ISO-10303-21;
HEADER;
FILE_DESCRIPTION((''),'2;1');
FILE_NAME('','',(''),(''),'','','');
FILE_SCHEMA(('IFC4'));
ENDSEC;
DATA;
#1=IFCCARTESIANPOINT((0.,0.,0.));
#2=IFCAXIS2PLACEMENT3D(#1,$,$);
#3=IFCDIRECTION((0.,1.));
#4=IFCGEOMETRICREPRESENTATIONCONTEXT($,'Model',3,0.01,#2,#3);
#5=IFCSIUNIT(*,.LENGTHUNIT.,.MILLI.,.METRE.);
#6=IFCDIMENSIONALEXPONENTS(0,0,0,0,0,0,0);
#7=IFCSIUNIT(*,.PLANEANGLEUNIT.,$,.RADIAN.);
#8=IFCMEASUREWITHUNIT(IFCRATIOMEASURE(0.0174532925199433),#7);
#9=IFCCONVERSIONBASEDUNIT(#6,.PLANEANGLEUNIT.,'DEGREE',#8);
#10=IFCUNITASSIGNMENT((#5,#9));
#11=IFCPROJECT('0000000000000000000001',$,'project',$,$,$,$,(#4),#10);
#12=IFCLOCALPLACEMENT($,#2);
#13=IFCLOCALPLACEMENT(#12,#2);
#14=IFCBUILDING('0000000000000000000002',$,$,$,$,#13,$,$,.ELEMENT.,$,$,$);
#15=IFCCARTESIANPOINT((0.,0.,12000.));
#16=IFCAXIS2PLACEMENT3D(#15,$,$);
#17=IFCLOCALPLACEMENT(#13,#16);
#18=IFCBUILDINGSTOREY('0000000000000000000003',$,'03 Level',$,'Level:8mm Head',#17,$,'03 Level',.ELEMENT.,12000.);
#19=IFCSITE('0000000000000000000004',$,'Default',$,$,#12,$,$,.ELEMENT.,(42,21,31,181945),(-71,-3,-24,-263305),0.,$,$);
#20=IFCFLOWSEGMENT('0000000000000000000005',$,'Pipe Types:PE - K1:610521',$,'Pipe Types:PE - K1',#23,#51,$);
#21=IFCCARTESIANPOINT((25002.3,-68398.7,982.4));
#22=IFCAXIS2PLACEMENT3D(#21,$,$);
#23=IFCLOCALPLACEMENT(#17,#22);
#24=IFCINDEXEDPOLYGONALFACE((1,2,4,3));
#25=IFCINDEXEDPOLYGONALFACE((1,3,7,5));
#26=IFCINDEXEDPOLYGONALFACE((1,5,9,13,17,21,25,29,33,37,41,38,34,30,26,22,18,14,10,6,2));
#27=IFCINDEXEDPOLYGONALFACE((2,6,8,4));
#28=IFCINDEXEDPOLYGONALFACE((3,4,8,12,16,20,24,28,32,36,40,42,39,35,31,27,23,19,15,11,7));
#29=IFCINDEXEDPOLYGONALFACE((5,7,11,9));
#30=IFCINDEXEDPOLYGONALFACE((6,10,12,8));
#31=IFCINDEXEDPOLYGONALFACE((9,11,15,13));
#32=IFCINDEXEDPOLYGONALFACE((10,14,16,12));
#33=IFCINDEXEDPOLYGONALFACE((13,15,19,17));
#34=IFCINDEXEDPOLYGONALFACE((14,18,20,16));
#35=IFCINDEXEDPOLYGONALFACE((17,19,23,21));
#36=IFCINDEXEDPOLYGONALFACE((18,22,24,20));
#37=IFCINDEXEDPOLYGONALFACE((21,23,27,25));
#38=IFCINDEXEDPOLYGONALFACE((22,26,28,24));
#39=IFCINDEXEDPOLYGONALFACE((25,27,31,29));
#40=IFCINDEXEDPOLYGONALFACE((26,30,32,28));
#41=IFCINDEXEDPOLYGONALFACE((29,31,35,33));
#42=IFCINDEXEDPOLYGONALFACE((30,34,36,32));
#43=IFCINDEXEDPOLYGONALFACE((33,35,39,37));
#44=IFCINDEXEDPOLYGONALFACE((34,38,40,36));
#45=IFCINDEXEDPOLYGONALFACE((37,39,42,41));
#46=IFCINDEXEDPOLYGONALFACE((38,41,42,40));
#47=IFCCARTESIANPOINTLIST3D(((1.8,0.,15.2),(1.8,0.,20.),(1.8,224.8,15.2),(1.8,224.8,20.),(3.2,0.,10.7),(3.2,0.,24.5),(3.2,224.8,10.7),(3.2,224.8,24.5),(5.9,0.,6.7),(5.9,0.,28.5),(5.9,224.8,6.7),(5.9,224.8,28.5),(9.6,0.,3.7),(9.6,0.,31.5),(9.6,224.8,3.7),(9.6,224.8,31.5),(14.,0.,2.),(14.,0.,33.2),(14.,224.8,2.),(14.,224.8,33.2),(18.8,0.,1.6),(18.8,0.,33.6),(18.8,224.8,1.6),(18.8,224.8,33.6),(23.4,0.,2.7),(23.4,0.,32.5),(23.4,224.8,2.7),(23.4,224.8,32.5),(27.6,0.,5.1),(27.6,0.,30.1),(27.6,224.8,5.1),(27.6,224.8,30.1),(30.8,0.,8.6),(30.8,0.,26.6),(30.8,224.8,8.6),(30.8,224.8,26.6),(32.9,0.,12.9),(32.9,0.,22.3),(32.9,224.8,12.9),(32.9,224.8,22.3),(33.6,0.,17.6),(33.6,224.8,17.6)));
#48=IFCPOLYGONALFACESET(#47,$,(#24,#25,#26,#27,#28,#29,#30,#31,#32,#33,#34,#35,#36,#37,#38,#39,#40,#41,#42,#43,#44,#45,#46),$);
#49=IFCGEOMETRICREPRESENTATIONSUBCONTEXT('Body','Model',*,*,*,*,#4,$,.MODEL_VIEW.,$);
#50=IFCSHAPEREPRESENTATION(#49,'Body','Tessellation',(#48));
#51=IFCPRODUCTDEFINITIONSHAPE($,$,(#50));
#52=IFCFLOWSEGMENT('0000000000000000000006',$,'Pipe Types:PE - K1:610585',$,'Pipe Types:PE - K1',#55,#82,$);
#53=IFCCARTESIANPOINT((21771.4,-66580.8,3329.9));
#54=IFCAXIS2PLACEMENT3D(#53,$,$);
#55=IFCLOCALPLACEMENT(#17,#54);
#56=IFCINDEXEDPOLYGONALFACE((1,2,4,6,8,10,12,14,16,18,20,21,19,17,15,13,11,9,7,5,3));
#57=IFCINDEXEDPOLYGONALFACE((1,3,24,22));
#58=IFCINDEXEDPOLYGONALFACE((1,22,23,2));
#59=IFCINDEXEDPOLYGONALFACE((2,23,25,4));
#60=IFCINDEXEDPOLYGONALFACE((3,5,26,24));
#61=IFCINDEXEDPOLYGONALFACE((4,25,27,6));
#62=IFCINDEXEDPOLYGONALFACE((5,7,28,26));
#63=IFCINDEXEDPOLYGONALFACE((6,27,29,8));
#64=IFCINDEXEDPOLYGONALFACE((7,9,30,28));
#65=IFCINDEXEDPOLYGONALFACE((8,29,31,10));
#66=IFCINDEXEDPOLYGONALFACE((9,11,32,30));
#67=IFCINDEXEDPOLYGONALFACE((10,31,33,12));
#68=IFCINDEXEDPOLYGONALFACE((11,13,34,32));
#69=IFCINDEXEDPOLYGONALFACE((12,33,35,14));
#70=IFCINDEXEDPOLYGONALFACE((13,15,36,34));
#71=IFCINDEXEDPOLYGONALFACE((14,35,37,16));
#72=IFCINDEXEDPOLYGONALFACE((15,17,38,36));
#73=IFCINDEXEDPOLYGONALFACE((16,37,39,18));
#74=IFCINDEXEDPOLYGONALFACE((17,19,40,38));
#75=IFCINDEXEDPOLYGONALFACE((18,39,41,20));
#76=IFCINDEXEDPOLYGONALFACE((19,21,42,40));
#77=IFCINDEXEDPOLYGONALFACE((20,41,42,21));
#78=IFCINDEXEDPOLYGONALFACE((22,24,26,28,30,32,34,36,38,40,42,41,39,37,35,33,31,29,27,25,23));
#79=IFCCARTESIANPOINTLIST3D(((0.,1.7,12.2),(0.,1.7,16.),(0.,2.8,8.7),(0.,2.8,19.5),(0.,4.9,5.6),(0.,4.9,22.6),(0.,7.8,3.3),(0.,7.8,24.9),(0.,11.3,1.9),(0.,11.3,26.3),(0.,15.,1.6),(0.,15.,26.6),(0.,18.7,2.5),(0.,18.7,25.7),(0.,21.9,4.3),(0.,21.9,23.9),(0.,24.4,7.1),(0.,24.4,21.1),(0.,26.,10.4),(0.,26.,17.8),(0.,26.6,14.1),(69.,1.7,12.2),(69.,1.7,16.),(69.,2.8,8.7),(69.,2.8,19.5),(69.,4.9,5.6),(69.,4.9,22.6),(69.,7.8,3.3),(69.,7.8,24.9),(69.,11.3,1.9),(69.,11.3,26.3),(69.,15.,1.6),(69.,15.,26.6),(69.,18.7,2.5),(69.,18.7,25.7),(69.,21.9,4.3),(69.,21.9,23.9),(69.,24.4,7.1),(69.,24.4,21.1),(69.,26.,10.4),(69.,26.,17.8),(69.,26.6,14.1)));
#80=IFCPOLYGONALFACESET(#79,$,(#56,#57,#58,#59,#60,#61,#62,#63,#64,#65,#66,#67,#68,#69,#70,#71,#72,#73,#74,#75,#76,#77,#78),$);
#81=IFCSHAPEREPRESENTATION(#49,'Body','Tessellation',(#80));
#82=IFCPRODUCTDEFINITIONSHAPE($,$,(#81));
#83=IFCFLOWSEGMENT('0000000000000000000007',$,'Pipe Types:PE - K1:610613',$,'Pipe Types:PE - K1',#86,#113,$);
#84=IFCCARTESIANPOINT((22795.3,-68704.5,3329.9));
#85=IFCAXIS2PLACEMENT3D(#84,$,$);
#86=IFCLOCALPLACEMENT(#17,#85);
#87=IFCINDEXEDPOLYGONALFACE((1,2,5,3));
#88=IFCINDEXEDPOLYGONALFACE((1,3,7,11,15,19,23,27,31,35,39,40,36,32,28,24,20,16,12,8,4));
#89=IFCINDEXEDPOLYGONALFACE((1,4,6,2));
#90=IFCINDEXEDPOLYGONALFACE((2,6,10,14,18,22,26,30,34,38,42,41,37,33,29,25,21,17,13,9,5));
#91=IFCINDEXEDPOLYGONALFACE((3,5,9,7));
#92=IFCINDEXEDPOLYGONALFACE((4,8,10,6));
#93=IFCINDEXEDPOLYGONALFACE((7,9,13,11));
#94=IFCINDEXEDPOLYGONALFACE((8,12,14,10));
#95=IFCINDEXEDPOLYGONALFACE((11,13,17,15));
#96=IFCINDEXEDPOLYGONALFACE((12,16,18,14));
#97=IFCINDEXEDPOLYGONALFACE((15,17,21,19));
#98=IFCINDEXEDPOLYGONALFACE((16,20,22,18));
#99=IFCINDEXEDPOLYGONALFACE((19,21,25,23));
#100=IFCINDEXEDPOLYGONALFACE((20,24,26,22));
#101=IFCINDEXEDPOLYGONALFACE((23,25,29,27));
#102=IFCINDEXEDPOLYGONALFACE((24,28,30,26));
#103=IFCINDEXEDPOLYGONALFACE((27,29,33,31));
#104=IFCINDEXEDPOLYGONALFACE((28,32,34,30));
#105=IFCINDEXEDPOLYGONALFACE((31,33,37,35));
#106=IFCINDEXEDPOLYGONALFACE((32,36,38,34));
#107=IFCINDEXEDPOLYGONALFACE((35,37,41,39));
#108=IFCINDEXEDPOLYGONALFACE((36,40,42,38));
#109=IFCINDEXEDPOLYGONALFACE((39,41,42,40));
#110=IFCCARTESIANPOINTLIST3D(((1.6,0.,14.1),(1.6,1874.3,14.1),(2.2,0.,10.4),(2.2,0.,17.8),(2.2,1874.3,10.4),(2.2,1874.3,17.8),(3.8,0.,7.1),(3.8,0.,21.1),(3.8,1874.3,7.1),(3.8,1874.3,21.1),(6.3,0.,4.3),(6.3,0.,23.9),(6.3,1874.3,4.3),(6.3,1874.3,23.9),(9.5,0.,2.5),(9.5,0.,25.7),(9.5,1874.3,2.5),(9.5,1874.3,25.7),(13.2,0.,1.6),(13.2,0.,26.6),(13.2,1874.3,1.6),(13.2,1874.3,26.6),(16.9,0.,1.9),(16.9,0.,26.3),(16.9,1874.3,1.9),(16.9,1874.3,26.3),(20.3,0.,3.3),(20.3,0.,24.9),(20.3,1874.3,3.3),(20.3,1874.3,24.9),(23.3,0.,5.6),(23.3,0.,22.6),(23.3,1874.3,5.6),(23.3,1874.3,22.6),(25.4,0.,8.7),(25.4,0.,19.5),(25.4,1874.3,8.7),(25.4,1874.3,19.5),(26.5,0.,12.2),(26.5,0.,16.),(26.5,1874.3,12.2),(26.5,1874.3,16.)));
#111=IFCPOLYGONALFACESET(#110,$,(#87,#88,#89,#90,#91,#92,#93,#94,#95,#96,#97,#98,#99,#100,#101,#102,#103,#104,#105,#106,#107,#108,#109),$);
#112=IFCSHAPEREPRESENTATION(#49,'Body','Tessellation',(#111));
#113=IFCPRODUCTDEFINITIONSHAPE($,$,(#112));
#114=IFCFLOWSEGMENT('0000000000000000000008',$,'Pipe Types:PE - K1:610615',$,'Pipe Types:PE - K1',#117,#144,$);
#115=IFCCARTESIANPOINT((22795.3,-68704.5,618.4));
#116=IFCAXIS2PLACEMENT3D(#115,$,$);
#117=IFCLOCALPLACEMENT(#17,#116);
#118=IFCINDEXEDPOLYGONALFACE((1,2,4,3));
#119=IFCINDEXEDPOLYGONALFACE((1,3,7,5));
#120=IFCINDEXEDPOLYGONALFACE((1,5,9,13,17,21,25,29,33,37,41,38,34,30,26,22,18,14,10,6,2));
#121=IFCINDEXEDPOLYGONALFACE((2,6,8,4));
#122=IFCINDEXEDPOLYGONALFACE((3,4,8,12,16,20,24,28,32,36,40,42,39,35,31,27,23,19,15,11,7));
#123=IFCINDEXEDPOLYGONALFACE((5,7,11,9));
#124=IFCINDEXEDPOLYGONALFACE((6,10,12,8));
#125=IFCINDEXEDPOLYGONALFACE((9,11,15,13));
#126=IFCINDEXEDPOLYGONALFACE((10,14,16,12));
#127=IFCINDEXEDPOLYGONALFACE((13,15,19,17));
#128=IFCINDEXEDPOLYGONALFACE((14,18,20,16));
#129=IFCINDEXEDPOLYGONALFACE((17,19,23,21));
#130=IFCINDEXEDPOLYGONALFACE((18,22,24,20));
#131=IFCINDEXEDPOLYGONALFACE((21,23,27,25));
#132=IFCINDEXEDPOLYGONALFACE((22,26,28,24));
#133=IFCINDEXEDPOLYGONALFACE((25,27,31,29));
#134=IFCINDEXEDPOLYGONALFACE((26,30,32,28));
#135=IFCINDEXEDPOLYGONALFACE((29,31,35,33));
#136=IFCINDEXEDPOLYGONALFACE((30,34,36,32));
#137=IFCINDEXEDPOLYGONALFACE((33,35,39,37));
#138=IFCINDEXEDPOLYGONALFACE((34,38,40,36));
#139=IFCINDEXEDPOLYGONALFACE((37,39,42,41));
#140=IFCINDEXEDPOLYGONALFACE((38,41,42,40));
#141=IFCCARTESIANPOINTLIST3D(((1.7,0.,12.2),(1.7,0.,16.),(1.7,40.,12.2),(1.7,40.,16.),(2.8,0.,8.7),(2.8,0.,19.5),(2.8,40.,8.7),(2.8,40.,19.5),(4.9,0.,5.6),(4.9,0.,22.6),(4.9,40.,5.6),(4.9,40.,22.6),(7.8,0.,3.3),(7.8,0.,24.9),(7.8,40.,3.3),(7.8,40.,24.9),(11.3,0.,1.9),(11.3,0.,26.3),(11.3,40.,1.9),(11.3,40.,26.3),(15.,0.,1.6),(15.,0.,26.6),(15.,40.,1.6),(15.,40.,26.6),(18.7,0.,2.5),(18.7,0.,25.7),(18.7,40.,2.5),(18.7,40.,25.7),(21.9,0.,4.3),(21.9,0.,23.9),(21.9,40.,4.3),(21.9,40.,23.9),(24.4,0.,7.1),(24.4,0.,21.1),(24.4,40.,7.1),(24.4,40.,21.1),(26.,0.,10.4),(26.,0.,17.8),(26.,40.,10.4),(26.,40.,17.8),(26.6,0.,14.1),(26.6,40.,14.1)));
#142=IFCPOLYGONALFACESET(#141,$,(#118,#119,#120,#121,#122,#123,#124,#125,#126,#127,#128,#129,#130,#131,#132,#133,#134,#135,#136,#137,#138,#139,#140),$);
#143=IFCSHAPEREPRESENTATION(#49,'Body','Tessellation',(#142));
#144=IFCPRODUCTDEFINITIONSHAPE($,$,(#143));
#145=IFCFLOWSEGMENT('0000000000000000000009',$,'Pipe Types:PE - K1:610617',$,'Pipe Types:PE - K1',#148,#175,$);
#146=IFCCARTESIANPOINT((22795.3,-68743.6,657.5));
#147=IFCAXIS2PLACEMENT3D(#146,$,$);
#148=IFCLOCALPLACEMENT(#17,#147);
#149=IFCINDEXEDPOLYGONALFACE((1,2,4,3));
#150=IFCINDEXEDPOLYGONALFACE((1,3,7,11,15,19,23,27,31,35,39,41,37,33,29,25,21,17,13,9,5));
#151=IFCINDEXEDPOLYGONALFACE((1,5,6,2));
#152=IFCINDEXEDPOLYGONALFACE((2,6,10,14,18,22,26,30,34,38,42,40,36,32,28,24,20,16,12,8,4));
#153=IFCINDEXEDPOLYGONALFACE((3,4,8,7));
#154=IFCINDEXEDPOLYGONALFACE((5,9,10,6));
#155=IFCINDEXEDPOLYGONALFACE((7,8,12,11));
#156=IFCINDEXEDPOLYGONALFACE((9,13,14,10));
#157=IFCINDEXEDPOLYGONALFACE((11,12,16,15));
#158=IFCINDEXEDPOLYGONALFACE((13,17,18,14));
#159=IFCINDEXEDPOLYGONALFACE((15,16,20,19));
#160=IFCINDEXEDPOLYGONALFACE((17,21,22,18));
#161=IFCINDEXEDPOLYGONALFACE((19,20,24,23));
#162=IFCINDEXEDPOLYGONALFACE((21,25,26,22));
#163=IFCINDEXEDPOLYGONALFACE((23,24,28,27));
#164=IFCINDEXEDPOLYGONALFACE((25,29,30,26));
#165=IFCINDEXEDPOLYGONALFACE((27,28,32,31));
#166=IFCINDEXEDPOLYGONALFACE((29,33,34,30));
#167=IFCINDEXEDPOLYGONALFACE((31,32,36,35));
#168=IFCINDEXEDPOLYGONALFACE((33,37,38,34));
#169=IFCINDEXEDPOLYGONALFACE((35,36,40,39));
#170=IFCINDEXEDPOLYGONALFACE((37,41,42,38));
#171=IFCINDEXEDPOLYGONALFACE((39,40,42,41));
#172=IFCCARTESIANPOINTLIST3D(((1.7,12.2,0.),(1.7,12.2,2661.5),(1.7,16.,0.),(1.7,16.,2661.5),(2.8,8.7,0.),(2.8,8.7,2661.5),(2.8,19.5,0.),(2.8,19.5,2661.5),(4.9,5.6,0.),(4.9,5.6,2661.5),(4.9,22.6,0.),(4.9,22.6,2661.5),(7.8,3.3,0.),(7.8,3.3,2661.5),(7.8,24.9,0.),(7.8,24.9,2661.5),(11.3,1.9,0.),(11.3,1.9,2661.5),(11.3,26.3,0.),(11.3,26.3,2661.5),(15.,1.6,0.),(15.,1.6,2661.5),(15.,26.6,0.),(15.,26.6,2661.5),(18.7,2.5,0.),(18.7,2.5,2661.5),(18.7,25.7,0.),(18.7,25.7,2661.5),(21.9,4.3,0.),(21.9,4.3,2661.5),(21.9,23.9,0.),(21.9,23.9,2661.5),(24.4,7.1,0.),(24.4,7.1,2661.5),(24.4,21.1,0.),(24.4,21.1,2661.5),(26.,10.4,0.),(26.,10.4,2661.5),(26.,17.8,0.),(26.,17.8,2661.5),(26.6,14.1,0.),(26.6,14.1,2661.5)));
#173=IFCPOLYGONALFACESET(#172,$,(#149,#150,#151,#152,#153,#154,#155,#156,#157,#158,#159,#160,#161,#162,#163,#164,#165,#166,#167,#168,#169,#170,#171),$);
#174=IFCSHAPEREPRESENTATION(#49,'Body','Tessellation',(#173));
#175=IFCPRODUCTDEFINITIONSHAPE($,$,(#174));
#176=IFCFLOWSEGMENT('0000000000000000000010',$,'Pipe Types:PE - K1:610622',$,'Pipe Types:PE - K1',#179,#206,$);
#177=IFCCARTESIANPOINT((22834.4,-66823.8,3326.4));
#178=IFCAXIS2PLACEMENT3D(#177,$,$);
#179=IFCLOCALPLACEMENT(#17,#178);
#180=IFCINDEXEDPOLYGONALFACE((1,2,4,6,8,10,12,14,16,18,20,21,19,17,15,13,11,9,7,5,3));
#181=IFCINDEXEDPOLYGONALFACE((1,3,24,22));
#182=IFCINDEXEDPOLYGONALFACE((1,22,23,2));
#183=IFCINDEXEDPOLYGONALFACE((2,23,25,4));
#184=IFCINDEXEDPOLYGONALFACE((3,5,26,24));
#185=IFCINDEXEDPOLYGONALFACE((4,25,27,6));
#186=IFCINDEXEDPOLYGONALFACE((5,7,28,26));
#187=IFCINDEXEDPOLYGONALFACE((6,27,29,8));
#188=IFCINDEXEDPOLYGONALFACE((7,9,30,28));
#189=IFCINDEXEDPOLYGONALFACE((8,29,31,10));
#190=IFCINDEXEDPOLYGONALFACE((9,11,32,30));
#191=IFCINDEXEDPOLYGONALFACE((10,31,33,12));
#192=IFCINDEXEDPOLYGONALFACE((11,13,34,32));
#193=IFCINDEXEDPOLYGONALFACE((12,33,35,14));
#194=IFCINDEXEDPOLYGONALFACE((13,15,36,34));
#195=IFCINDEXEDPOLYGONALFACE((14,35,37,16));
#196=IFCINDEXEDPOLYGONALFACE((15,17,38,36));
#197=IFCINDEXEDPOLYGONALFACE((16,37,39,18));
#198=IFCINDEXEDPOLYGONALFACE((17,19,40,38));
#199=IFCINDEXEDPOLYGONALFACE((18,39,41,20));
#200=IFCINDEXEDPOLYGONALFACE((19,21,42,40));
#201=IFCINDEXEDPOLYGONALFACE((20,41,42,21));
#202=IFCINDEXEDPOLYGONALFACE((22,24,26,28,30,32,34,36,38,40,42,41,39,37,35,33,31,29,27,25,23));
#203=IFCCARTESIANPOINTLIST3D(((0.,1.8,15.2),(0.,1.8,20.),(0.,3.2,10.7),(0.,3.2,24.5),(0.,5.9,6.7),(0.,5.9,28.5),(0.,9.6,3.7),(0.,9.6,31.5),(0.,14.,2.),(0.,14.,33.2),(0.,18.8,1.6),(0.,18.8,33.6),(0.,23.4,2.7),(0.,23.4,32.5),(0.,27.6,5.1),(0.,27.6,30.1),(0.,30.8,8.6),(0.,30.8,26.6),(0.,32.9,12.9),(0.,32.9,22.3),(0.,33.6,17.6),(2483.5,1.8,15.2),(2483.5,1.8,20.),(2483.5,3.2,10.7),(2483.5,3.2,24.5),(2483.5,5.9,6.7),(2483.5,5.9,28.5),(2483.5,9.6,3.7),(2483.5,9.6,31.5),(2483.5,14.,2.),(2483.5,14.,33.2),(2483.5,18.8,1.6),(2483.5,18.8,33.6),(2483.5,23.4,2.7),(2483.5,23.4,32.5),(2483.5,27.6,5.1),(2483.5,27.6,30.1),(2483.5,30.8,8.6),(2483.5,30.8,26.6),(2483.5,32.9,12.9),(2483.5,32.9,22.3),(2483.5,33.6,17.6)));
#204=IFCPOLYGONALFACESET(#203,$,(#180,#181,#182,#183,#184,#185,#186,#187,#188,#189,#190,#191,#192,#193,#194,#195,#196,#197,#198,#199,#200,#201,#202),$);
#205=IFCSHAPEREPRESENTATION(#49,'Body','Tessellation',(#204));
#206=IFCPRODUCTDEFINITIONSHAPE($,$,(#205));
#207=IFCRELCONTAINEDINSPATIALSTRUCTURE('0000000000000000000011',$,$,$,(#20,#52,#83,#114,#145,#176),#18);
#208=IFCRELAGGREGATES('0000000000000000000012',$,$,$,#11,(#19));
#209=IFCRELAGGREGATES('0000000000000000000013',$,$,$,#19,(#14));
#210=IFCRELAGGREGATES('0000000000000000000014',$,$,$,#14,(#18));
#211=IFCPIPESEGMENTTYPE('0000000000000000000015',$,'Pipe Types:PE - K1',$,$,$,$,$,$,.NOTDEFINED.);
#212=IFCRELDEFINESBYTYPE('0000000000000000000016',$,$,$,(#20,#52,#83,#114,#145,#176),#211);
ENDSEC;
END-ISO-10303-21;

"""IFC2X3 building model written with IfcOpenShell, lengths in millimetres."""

from ifc_helpers import new_model, entity, si_unit, converted_unit, direction, frame, frame_2d, origin, origin_2d_with_axis, place, context, subcontext, project, spatial, circle, extrude, type_object, element, save


model = new_model("IFC2X3")

# Units and contexts
model_context = context("Model", 3, precision=0.01, world=origin(), true_north=direction((0.0, 1.0)))
body_context = subcontext(model_context, "Body", "Model", "MODEL_VIEW")
ifc_project = project(units=[si_unit("LENGTHUNIT", "METRE", prefix="MILLI"), converted_unit("PLANEANGLEUNIT", "DEGREE", entity("IfcRatioMeasure", 0.0174532925199433), si_unit("PLANEANGLEUNIT", "RADIAN"), dimensions=[0, 0, 0, 0, 0, 0, 0])], contexts=[model_context])

# Site, building, storey
site_placement = place(None, origin())
site = spatial("IfcSite", under=ifc_project, at=site_placement, Name="Default", CompositionType="ELEMENT", RefLatitude=(42, 21, 31, 181945), RefLongitude=(-71, -3, -24, -263305), RefElevation=0.0)
building_placement = place(site_placement, origin())
building = spatial("IfcBuilding", under=site, at=building_placement, CompositionType="ELEMENT")
storey_placement = place(building_placement, frame((0.0, 0.0, 12000.0)))
storey = spatial("IfcBuildingStorey", under=building, at=storey_placement, Name="03 Level", ObjectType="Level:8mm Head", LongName="03 Level", CompositionType="ELEMENT", Elevation=12000.0)

# Flow segments
pipe_segment_type = type_object("IfcPipeSegmentType", Name="Pipe Types:PE - K1", PredefinedType="NOTDEFINED")
flow_segment_1_placement = place(storey_placement, frame((25002.3, -68398.7, 982.4)))
element("IfcFlowSegment", 1, at=flow_segment_1_placement, inside=storey, type_object=pipe_segment_type, Name="Pipe Types:PE - K1:610521", ObjectType="Pipe Types:PE - K1", context=body_context, shape_type="SweptSolid", body=[
    extrude(circle(Radius=16.0, at=origin_2d_with_axis()), frame((17.6, 0.0, 17.6), z_axis=(0.0, 1.0, 0.0), x_axis=(1.0, 0.0, 0.0)), (0.0, 0.0, 1.0), 224.8),
])
flow_segment_2_placement = place(storey_placement, frame((21771.4, -66580.8, 3329.9)))
element("IfcFlowSegment", 2, at=flow_segment_2_placement, inside=storey, type_object=pipe_segment_type, Name="Pipe Types:PE - K1:610585", ObjectType="Pipe Types:PE - K1", context=body_context, shape_type="SweptSolid", body=[
    extrude(circle(Radius=12.5, at=frame_2d((0.0, 0.0), x_axis=(1.0, 0.0))), frame((0.0, 14.1, 14.1), z_axis=(1.0, 0.0, 0.0), x_axis=(0.0, 1.0, 0.0)), (0.0, 0.0, 1.0), 69.0),
])
flow_segment_3_placement = place(storey_placement, frame((22795.3, -68704.5, 3329.9)))
element("IfcFlowSegment", 3, at=flow_segment_3_placement, inside=storey, type_object=pipe_segment_type, Name="Pipe Types:PE - K1:610613", ObjectType="Pipe Types:PE - K1", context=body_context, shape_type="SweptSolid", body=[
    extrude(circle(Radius=12.5, at=frame_2d((0.0, 0.0), x_axis=(1.0, 0.0))), frame((14.1, 0.0, 14.1), z_axis=(0.0, 1.0, 0.0), x_axis=(-1.0, 0.0, 0.0)), (0.0, 0.0, 1.0), 1874.3),
])
flow_segment_4_placement = place(storey_placement, frame((22795.3, -68704.5, 618.4)))
element("IfcFlowSegment", 4, at=flow_segment_4_placement, inside=storey, type_object=pipe_segment_type, Name="Pipe Types:PE - K1:610615", ObjectType="Pipe Types:PE - K1", context=body_context, shape_type="SweptSolid", body=[
    extrude(circle(Radius=12.5, at=origin_2d_with_axis()), frame((14.1, 0.0, 14.1), z_axis=(0.0, 1.0, 0.0), x_axis=(1.0, 0.0, 0.0)), (0.0, 0.0, 1.0), 40.0),
])
flow_segment_5_placement = place(storey_placement, frame((22795.3, -68743.6, 657.5)))
element("IfcFlowSegment", 5, at=flow_segment_5_placement, inside=storey, type_object=pipe_segment_type, Name="Pipe Types:PE - K1:610617", ObjectType="Pipe Types:PE - K1", context=body_context, shape_type="SweptSolid", body=[
    extrude(circle(Radius=12.5, at=frame_2d((0.0, 0.0), x_axis=(1.0, 0.0))), frame((14.1, 14.1, 0.0)), (0.0, 0.0, 1.0), 2661.5),
])
flow_segment_6_placement = place(storey_placement, frame((22834.4, -66823.8, 3326.4)))
element("IfcFlowSegment", 6, at=flow_segment_6_placement, inside=storey, type_object=pipe_segment_type, Name="Pipe Types:PE - K1:610622", ObjectType="Pipe Types:PE - K1", context=body_context, shape_type="SweptSolid", body=[
    extrude(circle(Radius=16.0, at=frame_2d((0.0, 0.0), x_axis=(1.0, 0.0))), frame((0.0, 17.6, 17.6), z_axis=(1.0, 0.0, 0.0), x_axis=(0.0, 1.0, 0.0)), (0.0, 0.0, 1.0), 2483.5),
])

save(model, "model.ifc")
